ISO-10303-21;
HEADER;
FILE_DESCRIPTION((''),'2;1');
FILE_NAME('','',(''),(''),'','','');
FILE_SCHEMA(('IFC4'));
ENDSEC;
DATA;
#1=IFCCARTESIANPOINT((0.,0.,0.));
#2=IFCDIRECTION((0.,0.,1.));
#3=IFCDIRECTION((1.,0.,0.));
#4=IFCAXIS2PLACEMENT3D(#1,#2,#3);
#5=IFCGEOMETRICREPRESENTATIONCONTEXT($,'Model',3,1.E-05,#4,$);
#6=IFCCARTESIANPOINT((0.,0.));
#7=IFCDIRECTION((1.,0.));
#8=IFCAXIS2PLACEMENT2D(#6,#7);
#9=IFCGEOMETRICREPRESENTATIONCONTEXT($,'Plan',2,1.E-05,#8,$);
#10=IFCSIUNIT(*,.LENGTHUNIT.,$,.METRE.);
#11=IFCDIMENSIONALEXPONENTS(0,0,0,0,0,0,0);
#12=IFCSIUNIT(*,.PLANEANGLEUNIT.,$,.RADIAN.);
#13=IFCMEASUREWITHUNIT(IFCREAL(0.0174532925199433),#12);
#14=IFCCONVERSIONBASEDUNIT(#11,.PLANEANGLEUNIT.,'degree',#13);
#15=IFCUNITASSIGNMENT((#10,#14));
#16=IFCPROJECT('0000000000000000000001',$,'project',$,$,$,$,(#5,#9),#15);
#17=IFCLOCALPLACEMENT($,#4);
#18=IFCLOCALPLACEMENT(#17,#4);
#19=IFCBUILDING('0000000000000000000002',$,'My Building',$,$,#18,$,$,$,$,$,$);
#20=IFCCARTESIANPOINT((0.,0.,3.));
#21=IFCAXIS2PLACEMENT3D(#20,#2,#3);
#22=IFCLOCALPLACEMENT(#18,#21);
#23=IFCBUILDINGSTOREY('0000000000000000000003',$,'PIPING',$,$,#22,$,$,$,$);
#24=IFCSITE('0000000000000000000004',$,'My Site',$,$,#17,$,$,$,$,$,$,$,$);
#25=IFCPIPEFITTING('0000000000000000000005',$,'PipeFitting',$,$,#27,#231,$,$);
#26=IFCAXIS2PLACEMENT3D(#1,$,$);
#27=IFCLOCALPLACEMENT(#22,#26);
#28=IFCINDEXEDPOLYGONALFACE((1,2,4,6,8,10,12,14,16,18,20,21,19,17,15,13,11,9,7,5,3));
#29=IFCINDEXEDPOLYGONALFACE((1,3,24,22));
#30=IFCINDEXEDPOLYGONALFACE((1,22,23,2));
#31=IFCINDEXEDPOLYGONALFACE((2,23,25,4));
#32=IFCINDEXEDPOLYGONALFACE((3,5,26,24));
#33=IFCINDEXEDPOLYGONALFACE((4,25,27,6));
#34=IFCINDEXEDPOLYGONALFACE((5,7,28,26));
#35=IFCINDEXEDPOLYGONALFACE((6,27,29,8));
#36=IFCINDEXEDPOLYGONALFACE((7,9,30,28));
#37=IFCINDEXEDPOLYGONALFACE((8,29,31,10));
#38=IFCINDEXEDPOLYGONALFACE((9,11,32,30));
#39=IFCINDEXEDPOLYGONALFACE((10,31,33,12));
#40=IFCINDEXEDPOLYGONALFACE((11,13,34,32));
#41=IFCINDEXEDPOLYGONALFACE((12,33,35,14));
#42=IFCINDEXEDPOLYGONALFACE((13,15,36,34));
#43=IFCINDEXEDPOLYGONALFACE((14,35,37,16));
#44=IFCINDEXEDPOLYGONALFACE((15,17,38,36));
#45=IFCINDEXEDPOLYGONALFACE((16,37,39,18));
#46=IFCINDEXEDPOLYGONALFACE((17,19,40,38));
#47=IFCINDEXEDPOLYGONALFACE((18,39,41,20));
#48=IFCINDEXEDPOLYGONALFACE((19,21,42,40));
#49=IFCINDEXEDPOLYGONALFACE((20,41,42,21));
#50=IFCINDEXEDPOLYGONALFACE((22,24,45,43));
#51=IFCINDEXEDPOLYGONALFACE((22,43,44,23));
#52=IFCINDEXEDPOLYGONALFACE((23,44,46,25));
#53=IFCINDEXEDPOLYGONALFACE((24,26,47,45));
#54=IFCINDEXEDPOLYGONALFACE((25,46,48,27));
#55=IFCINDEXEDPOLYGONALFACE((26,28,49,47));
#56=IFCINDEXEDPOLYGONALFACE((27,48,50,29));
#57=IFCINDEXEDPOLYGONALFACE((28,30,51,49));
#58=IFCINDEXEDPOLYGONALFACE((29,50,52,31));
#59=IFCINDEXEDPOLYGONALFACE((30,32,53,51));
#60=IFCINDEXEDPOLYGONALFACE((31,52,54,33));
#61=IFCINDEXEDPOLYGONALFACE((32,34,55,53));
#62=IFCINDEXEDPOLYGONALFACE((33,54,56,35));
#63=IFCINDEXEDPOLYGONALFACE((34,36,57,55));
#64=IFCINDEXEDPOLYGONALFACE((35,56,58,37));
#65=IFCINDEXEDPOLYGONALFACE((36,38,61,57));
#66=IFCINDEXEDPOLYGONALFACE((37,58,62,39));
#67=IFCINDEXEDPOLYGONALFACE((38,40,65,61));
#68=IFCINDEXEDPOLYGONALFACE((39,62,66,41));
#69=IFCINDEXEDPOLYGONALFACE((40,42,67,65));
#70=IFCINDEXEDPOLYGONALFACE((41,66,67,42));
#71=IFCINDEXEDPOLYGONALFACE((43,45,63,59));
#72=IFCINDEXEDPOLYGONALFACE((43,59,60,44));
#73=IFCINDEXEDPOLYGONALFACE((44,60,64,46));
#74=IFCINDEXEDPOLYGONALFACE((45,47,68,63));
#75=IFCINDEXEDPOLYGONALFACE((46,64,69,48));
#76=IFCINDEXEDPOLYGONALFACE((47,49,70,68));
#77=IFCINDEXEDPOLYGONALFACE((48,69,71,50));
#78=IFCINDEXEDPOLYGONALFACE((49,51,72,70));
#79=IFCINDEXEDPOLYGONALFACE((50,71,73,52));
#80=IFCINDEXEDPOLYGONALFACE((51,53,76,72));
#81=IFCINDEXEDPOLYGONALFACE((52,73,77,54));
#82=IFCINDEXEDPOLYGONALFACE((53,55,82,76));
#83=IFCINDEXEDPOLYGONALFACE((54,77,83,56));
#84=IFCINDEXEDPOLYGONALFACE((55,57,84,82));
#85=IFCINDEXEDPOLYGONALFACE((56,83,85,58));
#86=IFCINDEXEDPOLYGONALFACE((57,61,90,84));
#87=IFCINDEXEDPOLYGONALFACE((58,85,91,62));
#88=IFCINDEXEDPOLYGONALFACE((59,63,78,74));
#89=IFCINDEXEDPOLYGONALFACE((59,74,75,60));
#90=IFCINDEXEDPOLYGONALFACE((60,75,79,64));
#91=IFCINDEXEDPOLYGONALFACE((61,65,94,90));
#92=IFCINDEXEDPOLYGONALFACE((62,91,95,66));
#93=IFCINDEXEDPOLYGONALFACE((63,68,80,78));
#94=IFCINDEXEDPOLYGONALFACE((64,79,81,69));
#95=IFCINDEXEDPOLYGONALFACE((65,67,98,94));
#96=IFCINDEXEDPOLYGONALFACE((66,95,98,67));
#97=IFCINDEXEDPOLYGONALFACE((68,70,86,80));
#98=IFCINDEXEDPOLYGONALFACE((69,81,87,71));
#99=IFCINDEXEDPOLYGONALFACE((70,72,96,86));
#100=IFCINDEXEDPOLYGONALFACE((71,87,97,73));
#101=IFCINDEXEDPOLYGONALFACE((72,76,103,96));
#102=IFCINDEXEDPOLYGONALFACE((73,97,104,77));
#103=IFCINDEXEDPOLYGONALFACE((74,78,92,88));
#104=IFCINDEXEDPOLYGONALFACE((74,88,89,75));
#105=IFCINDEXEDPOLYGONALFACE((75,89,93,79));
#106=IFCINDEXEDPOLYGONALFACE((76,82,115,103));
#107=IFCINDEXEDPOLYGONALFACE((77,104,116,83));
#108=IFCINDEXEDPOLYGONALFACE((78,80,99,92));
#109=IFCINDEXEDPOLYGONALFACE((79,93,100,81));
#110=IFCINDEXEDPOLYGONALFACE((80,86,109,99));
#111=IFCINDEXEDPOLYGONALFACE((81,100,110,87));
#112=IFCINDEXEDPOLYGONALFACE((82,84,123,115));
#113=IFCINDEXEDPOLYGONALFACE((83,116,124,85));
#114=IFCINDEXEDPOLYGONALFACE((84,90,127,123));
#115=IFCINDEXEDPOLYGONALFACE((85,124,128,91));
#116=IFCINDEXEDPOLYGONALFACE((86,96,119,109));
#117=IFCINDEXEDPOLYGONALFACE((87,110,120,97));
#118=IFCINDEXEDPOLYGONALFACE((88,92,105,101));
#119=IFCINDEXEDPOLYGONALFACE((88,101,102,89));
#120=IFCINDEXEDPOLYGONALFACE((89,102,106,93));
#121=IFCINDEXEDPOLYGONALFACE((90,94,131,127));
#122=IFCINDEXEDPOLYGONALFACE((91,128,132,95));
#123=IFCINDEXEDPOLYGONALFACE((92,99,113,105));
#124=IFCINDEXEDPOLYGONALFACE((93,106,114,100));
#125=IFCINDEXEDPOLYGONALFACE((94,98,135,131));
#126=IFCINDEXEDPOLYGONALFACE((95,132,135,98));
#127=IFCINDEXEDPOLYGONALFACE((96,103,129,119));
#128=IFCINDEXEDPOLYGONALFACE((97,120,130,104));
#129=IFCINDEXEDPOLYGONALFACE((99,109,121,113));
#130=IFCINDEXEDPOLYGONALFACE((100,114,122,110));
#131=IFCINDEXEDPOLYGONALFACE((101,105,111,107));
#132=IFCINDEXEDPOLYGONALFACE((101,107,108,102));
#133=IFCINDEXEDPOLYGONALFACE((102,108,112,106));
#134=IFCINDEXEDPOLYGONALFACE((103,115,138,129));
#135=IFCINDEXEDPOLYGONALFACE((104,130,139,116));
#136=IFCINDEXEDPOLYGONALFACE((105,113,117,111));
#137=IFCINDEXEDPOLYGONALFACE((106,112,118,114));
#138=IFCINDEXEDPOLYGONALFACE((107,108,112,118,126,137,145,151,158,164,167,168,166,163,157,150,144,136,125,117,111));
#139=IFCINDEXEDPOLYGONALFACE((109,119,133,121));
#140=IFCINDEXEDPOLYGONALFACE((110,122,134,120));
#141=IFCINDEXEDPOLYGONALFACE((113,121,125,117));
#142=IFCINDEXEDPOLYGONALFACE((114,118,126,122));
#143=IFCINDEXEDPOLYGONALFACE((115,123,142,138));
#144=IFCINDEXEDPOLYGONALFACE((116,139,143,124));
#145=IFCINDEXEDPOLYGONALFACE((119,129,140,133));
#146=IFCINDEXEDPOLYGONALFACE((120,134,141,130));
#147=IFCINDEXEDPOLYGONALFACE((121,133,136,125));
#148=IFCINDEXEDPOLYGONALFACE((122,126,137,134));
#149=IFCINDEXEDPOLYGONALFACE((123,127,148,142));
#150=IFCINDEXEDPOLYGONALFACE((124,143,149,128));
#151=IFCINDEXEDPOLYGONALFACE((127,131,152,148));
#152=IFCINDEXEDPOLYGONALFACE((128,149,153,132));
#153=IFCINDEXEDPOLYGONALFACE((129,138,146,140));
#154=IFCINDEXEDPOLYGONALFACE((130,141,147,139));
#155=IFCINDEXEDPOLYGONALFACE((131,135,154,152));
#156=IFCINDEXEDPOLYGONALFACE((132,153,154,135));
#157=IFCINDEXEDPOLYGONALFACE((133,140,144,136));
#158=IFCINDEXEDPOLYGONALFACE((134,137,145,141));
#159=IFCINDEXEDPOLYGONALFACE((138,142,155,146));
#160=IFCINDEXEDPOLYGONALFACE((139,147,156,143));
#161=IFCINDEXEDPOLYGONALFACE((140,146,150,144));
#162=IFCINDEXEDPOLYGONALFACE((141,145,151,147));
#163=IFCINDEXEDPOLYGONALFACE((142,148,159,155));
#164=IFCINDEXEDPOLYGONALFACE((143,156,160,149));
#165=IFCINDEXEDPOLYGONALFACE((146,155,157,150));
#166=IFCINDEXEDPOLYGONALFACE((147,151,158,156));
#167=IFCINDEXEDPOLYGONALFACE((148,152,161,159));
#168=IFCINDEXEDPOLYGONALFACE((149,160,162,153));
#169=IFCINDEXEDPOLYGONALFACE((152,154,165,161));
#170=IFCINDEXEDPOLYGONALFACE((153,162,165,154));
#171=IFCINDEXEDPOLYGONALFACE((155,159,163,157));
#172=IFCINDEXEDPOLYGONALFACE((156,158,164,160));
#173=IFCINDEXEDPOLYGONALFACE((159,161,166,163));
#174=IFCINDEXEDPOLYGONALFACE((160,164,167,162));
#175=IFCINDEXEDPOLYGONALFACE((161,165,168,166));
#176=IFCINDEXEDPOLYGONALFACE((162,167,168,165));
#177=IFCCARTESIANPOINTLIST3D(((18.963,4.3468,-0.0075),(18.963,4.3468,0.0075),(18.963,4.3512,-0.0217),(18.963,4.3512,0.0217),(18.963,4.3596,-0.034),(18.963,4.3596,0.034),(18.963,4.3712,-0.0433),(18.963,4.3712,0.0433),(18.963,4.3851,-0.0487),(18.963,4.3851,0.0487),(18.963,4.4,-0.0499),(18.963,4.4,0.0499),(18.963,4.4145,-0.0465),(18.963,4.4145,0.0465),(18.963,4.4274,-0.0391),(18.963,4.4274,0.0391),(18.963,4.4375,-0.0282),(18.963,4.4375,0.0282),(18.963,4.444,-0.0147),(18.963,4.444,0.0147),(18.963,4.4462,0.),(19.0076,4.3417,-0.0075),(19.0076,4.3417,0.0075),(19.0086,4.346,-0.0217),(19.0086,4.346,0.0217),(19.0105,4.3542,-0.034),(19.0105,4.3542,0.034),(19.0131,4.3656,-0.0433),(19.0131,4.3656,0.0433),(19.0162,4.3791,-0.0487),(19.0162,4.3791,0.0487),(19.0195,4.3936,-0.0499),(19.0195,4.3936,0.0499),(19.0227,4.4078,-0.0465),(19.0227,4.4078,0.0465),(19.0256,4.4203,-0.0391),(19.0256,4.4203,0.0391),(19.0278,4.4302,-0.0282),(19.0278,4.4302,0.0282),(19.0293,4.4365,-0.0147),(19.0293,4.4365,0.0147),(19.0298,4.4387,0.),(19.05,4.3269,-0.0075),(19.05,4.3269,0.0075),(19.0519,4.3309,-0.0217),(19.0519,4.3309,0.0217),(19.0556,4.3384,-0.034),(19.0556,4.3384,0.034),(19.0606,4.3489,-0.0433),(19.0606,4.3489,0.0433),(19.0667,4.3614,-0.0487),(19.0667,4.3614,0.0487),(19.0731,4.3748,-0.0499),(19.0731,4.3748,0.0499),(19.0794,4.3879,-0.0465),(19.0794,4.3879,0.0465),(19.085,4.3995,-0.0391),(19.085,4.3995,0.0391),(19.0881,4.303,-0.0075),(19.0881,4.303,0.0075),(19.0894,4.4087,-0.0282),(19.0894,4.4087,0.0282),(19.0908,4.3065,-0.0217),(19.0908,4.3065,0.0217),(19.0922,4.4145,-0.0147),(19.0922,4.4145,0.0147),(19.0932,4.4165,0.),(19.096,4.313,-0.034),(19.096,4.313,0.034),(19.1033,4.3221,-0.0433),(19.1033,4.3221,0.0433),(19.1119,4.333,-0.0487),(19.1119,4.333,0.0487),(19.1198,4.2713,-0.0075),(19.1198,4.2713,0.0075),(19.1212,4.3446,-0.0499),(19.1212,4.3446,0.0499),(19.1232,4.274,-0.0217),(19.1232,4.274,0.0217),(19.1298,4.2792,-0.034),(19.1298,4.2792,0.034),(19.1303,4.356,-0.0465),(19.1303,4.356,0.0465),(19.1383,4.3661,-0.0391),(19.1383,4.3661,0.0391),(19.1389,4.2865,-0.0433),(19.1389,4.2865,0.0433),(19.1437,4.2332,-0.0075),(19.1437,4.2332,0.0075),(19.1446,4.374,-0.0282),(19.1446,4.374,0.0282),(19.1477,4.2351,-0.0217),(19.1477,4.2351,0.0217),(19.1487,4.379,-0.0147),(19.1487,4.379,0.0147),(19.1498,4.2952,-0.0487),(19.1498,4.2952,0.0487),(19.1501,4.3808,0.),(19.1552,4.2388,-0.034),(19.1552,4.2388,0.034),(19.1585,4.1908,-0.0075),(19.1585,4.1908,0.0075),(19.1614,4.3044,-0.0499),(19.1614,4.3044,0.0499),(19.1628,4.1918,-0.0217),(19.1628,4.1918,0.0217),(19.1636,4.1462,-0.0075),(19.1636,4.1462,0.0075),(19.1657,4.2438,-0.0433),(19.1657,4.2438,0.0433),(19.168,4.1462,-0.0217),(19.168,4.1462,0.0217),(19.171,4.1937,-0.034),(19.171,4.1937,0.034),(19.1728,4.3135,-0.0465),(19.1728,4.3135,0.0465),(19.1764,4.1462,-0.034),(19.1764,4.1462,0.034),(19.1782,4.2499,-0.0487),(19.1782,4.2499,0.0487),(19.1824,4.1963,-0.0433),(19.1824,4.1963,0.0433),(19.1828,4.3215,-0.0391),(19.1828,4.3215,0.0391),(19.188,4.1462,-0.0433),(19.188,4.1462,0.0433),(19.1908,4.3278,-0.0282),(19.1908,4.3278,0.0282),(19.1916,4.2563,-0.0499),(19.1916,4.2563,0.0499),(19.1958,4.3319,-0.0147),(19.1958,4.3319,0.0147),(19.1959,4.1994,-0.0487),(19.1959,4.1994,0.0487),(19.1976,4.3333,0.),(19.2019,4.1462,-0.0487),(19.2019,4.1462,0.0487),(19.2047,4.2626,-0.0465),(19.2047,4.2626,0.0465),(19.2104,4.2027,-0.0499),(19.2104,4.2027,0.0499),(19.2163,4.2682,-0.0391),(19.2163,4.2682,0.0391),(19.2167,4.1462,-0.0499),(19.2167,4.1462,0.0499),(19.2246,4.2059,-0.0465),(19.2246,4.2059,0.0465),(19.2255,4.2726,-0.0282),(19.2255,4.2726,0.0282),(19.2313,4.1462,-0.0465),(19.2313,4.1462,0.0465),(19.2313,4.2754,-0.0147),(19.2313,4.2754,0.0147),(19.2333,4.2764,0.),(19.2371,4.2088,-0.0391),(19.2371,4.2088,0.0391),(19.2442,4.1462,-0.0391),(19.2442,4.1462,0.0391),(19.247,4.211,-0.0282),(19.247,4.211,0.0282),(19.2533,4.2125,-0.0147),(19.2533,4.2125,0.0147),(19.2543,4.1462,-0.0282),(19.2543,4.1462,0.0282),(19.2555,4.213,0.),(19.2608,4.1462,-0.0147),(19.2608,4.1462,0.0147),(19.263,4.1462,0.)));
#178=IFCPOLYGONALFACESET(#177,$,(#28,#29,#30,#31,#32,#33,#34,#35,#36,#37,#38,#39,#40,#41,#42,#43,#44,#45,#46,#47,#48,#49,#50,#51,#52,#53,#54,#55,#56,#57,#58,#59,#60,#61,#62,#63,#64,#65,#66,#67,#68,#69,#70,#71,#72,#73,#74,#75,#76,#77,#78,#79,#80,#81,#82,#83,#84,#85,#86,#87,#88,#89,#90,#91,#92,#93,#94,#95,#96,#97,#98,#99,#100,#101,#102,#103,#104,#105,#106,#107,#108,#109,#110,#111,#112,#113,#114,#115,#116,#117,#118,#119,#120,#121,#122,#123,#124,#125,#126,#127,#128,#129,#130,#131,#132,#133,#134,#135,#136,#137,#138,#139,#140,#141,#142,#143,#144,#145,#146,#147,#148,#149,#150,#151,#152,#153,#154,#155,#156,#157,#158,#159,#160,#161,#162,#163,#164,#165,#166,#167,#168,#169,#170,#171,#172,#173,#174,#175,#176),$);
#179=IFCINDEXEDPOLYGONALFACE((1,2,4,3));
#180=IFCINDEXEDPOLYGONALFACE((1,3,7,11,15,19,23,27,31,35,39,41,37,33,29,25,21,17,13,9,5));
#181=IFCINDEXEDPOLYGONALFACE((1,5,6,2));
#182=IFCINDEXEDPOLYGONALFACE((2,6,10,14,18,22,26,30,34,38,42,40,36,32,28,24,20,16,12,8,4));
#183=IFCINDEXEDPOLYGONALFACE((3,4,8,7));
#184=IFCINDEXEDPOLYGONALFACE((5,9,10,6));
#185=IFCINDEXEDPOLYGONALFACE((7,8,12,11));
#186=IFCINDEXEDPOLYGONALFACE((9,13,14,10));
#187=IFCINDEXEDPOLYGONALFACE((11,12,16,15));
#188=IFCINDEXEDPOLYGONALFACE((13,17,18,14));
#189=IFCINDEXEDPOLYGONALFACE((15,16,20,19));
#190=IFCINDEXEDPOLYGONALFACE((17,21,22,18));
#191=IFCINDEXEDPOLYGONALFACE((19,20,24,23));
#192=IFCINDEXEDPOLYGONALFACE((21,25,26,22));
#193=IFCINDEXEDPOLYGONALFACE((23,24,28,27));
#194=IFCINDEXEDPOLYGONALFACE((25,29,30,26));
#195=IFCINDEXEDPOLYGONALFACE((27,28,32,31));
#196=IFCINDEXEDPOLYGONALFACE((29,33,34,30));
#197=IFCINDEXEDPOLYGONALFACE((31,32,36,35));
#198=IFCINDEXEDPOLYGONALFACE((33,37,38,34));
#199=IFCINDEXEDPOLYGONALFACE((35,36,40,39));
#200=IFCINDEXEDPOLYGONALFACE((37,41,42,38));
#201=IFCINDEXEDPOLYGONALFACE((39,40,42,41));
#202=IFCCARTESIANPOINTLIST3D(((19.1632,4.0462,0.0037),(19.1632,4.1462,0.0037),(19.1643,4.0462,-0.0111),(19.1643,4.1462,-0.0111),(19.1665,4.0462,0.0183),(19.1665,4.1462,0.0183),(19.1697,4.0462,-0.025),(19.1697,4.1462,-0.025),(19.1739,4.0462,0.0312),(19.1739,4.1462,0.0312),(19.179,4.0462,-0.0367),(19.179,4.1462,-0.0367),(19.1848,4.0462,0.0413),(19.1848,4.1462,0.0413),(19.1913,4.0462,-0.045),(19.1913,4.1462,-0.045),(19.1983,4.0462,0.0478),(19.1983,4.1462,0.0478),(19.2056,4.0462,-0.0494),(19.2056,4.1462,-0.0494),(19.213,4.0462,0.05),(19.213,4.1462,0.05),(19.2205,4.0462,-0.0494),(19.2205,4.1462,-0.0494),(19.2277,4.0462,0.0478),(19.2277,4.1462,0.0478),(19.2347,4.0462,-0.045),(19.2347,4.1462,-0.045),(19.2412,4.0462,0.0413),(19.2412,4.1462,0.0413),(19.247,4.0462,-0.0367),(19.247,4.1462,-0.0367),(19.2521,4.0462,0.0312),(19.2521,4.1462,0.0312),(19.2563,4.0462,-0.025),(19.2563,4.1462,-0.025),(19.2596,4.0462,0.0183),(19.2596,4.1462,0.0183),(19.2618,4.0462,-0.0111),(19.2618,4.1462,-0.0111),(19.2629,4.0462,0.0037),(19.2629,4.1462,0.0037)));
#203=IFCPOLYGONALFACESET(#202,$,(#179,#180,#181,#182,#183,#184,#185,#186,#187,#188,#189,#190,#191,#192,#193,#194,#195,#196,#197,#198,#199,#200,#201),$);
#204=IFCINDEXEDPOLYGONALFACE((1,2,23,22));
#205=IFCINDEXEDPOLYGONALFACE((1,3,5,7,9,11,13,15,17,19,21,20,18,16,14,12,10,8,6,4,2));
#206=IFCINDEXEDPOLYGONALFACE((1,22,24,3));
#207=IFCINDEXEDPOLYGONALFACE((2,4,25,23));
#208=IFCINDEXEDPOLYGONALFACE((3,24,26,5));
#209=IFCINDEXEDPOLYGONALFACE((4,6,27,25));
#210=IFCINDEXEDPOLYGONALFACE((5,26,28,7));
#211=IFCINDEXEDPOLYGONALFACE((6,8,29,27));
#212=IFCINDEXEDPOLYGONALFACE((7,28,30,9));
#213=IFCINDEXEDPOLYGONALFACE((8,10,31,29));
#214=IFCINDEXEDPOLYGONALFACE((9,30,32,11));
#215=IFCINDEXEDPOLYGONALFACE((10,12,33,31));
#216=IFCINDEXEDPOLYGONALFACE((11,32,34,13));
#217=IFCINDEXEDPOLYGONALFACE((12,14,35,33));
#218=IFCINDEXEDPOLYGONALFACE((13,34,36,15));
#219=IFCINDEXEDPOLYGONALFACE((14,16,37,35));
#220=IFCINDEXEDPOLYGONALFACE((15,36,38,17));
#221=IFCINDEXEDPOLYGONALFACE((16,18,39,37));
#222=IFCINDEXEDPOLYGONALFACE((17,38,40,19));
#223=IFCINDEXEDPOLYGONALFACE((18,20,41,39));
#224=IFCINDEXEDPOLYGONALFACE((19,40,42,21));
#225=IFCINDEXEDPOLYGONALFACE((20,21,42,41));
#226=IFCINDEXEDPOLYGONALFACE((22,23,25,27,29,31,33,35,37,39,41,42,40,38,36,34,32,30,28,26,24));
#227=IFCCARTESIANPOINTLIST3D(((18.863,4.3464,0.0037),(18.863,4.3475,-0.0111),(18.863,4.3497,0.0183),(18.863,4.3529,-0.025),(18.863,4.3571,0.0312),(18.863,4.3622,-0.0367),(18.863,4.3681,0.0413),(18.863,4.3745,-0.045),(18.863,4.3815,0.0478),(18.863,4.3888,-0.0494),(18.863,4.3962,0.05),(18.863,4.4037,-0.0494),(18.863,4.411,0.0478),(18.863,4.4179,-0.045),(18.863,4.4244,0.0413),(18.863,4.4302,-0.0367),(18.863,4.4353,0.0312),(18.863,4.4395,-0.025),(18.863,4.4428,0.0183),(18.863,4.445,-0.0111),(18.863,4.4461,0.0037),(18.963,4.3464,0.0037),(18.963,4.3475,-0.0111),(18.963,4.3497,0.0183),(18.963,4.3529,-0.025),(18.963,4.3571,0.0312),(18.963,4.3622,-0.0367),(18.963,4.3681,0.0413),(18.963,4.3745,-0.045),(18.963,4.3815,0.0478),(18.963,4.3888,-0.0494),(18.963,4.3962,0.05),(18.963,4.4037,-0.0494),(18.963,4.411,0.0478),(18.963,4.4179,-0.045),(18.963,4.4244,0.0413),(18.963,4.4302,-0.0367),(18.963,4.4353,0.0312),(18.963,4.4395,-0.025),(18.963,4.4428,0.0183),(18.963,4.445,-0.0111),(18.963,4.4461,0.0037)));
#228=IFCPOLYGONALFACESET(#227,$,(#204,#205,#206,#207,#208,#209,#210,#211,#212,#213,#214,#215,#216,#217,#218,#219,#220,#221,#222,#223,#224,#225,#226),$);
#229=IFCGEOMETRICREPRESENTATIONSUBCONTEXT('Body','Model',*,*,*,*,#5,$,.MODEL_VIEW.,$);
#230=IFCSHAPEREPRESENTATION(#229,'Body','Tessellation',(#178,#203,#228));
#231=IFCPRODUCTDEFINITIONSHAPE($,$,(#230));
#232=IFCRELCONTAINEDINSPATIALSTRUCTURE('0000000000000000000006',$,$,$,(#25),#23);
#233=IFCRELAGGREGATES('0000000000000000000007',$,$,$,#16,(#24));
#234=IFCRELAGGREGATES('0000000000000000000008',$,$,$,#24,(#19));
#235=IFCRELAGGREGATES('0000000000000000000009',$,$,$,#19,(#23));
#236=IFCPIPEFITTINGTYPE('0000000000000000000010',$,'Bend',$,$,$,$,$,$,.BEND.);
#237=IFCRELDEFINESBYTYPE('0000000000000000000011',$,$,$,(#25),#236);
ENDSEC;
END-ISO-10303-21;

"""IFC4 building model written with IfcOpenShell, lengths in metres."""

from ifc_helpers import new_model, entity, si_unit, converted_unit, frame, origin_with_axes, origin_2d_with_axis, place, context, subcontext, project, spatial, circle, extrude, source, transform, mapped, type_object, type_shapes, element, save


model = new_model("IFC4")

# Units and contexts
model_context = context("Model", 3, precision=1e-05, world=origin_with_axes())
plan_context = context("Plan", 2, precision=1e-05, world=origin_2d_with_axis())
body_context = subcontext(model_context, "Body", "Model", "MODEL_VIEW")
ifc_project = project(units=[si_unit("LENGTHUNIT", "METRE"), converted_unit("PLANEANGLEUNIT", "degree", entity("IfcReal", 0.0174532925199433), si_unit("PLANEANGLEUNIT", "RADIAN"), dimensions=[0, 0, 0, 0, 0, 0, 0])], contexts=[model_context, plan_context])

# Site, building, storey
site_placement = place(None, origin_with_axes())
site = spatial("IfcSite", under=ifc_project, at=site_placement, Name="My Site")
building_placement = place(site_placement, origin_with_axes())
building = spatial("IfcBuilding", under=site, at=building_placement, Name="My Building")
storey_placement = place(building_placement, frame((0.0, 0.0, 3.0), z_axis=(0.0, 0.0, 1.0), x_axis=(1.0, 0.0, 0.0)))
storey = spatial("IfcBuildingStorey", under=building, at=storey_placement, Name="PIPING")

# Shared definitions
pipe_fitting_type_1 = type_object("IfcPipeFittingType", Name="Bend", PredefinedType="BEND")
shared_shape = source(origin_with_axes(), body_context, "Body", "SolidModel", [
    entity("IfcSweptDiskSolid", entity("IfcIndexedPolyCurve", entity("IfcCartesianPointList3D", [[0.0, 0.0, -0.1], [0.0, 0.0732, -0.2768], [0.0, 0.25, -0.35]]), [entity("IfcArcIndex", [1, 2, 3])]), 0.05),
    extrude(circle(Radius=0.05), origin_with_axes(), (0.0, 0.0, -1.0), 0.1),
    extrude(circle(Radius=0.05), frame((0.0, 0.25, -0.35), z_axis=(0.0, 1.0, 0.0), x_axis=(1.0, 0.0, 0.0)), (0.0, 0.0, 1.0), 0.1),
])
type_shapes(pipe_fitting_type_1, [shared_shape])

# Pipe fitting
pipe_fitting_1_placement = place(storey_placement, frame((19.213, 4.0462, 0.0), z_axis=(0.0, -1.0, 0.0), x_axis=(0.0, 0.0, 1.0)))
element("IfcPipeFitting", 1, at=pipe_fitting_1_placement, inside=storey, type_object=pipe_fitting_type_1, Name="PipeFitting", context=body_context, shape_type="MappedRepresentation", body=[
    mapped(shared_shape, transform((0.0, 0.0, 0.0), x_axis=(1.0, 0.0, 0.0), y_axis=(0.0, 1.0, 0.0), z_axis=(0.0, 0.0, 1.0), scale=1.0)),
])

save(model, "model.ifc")
